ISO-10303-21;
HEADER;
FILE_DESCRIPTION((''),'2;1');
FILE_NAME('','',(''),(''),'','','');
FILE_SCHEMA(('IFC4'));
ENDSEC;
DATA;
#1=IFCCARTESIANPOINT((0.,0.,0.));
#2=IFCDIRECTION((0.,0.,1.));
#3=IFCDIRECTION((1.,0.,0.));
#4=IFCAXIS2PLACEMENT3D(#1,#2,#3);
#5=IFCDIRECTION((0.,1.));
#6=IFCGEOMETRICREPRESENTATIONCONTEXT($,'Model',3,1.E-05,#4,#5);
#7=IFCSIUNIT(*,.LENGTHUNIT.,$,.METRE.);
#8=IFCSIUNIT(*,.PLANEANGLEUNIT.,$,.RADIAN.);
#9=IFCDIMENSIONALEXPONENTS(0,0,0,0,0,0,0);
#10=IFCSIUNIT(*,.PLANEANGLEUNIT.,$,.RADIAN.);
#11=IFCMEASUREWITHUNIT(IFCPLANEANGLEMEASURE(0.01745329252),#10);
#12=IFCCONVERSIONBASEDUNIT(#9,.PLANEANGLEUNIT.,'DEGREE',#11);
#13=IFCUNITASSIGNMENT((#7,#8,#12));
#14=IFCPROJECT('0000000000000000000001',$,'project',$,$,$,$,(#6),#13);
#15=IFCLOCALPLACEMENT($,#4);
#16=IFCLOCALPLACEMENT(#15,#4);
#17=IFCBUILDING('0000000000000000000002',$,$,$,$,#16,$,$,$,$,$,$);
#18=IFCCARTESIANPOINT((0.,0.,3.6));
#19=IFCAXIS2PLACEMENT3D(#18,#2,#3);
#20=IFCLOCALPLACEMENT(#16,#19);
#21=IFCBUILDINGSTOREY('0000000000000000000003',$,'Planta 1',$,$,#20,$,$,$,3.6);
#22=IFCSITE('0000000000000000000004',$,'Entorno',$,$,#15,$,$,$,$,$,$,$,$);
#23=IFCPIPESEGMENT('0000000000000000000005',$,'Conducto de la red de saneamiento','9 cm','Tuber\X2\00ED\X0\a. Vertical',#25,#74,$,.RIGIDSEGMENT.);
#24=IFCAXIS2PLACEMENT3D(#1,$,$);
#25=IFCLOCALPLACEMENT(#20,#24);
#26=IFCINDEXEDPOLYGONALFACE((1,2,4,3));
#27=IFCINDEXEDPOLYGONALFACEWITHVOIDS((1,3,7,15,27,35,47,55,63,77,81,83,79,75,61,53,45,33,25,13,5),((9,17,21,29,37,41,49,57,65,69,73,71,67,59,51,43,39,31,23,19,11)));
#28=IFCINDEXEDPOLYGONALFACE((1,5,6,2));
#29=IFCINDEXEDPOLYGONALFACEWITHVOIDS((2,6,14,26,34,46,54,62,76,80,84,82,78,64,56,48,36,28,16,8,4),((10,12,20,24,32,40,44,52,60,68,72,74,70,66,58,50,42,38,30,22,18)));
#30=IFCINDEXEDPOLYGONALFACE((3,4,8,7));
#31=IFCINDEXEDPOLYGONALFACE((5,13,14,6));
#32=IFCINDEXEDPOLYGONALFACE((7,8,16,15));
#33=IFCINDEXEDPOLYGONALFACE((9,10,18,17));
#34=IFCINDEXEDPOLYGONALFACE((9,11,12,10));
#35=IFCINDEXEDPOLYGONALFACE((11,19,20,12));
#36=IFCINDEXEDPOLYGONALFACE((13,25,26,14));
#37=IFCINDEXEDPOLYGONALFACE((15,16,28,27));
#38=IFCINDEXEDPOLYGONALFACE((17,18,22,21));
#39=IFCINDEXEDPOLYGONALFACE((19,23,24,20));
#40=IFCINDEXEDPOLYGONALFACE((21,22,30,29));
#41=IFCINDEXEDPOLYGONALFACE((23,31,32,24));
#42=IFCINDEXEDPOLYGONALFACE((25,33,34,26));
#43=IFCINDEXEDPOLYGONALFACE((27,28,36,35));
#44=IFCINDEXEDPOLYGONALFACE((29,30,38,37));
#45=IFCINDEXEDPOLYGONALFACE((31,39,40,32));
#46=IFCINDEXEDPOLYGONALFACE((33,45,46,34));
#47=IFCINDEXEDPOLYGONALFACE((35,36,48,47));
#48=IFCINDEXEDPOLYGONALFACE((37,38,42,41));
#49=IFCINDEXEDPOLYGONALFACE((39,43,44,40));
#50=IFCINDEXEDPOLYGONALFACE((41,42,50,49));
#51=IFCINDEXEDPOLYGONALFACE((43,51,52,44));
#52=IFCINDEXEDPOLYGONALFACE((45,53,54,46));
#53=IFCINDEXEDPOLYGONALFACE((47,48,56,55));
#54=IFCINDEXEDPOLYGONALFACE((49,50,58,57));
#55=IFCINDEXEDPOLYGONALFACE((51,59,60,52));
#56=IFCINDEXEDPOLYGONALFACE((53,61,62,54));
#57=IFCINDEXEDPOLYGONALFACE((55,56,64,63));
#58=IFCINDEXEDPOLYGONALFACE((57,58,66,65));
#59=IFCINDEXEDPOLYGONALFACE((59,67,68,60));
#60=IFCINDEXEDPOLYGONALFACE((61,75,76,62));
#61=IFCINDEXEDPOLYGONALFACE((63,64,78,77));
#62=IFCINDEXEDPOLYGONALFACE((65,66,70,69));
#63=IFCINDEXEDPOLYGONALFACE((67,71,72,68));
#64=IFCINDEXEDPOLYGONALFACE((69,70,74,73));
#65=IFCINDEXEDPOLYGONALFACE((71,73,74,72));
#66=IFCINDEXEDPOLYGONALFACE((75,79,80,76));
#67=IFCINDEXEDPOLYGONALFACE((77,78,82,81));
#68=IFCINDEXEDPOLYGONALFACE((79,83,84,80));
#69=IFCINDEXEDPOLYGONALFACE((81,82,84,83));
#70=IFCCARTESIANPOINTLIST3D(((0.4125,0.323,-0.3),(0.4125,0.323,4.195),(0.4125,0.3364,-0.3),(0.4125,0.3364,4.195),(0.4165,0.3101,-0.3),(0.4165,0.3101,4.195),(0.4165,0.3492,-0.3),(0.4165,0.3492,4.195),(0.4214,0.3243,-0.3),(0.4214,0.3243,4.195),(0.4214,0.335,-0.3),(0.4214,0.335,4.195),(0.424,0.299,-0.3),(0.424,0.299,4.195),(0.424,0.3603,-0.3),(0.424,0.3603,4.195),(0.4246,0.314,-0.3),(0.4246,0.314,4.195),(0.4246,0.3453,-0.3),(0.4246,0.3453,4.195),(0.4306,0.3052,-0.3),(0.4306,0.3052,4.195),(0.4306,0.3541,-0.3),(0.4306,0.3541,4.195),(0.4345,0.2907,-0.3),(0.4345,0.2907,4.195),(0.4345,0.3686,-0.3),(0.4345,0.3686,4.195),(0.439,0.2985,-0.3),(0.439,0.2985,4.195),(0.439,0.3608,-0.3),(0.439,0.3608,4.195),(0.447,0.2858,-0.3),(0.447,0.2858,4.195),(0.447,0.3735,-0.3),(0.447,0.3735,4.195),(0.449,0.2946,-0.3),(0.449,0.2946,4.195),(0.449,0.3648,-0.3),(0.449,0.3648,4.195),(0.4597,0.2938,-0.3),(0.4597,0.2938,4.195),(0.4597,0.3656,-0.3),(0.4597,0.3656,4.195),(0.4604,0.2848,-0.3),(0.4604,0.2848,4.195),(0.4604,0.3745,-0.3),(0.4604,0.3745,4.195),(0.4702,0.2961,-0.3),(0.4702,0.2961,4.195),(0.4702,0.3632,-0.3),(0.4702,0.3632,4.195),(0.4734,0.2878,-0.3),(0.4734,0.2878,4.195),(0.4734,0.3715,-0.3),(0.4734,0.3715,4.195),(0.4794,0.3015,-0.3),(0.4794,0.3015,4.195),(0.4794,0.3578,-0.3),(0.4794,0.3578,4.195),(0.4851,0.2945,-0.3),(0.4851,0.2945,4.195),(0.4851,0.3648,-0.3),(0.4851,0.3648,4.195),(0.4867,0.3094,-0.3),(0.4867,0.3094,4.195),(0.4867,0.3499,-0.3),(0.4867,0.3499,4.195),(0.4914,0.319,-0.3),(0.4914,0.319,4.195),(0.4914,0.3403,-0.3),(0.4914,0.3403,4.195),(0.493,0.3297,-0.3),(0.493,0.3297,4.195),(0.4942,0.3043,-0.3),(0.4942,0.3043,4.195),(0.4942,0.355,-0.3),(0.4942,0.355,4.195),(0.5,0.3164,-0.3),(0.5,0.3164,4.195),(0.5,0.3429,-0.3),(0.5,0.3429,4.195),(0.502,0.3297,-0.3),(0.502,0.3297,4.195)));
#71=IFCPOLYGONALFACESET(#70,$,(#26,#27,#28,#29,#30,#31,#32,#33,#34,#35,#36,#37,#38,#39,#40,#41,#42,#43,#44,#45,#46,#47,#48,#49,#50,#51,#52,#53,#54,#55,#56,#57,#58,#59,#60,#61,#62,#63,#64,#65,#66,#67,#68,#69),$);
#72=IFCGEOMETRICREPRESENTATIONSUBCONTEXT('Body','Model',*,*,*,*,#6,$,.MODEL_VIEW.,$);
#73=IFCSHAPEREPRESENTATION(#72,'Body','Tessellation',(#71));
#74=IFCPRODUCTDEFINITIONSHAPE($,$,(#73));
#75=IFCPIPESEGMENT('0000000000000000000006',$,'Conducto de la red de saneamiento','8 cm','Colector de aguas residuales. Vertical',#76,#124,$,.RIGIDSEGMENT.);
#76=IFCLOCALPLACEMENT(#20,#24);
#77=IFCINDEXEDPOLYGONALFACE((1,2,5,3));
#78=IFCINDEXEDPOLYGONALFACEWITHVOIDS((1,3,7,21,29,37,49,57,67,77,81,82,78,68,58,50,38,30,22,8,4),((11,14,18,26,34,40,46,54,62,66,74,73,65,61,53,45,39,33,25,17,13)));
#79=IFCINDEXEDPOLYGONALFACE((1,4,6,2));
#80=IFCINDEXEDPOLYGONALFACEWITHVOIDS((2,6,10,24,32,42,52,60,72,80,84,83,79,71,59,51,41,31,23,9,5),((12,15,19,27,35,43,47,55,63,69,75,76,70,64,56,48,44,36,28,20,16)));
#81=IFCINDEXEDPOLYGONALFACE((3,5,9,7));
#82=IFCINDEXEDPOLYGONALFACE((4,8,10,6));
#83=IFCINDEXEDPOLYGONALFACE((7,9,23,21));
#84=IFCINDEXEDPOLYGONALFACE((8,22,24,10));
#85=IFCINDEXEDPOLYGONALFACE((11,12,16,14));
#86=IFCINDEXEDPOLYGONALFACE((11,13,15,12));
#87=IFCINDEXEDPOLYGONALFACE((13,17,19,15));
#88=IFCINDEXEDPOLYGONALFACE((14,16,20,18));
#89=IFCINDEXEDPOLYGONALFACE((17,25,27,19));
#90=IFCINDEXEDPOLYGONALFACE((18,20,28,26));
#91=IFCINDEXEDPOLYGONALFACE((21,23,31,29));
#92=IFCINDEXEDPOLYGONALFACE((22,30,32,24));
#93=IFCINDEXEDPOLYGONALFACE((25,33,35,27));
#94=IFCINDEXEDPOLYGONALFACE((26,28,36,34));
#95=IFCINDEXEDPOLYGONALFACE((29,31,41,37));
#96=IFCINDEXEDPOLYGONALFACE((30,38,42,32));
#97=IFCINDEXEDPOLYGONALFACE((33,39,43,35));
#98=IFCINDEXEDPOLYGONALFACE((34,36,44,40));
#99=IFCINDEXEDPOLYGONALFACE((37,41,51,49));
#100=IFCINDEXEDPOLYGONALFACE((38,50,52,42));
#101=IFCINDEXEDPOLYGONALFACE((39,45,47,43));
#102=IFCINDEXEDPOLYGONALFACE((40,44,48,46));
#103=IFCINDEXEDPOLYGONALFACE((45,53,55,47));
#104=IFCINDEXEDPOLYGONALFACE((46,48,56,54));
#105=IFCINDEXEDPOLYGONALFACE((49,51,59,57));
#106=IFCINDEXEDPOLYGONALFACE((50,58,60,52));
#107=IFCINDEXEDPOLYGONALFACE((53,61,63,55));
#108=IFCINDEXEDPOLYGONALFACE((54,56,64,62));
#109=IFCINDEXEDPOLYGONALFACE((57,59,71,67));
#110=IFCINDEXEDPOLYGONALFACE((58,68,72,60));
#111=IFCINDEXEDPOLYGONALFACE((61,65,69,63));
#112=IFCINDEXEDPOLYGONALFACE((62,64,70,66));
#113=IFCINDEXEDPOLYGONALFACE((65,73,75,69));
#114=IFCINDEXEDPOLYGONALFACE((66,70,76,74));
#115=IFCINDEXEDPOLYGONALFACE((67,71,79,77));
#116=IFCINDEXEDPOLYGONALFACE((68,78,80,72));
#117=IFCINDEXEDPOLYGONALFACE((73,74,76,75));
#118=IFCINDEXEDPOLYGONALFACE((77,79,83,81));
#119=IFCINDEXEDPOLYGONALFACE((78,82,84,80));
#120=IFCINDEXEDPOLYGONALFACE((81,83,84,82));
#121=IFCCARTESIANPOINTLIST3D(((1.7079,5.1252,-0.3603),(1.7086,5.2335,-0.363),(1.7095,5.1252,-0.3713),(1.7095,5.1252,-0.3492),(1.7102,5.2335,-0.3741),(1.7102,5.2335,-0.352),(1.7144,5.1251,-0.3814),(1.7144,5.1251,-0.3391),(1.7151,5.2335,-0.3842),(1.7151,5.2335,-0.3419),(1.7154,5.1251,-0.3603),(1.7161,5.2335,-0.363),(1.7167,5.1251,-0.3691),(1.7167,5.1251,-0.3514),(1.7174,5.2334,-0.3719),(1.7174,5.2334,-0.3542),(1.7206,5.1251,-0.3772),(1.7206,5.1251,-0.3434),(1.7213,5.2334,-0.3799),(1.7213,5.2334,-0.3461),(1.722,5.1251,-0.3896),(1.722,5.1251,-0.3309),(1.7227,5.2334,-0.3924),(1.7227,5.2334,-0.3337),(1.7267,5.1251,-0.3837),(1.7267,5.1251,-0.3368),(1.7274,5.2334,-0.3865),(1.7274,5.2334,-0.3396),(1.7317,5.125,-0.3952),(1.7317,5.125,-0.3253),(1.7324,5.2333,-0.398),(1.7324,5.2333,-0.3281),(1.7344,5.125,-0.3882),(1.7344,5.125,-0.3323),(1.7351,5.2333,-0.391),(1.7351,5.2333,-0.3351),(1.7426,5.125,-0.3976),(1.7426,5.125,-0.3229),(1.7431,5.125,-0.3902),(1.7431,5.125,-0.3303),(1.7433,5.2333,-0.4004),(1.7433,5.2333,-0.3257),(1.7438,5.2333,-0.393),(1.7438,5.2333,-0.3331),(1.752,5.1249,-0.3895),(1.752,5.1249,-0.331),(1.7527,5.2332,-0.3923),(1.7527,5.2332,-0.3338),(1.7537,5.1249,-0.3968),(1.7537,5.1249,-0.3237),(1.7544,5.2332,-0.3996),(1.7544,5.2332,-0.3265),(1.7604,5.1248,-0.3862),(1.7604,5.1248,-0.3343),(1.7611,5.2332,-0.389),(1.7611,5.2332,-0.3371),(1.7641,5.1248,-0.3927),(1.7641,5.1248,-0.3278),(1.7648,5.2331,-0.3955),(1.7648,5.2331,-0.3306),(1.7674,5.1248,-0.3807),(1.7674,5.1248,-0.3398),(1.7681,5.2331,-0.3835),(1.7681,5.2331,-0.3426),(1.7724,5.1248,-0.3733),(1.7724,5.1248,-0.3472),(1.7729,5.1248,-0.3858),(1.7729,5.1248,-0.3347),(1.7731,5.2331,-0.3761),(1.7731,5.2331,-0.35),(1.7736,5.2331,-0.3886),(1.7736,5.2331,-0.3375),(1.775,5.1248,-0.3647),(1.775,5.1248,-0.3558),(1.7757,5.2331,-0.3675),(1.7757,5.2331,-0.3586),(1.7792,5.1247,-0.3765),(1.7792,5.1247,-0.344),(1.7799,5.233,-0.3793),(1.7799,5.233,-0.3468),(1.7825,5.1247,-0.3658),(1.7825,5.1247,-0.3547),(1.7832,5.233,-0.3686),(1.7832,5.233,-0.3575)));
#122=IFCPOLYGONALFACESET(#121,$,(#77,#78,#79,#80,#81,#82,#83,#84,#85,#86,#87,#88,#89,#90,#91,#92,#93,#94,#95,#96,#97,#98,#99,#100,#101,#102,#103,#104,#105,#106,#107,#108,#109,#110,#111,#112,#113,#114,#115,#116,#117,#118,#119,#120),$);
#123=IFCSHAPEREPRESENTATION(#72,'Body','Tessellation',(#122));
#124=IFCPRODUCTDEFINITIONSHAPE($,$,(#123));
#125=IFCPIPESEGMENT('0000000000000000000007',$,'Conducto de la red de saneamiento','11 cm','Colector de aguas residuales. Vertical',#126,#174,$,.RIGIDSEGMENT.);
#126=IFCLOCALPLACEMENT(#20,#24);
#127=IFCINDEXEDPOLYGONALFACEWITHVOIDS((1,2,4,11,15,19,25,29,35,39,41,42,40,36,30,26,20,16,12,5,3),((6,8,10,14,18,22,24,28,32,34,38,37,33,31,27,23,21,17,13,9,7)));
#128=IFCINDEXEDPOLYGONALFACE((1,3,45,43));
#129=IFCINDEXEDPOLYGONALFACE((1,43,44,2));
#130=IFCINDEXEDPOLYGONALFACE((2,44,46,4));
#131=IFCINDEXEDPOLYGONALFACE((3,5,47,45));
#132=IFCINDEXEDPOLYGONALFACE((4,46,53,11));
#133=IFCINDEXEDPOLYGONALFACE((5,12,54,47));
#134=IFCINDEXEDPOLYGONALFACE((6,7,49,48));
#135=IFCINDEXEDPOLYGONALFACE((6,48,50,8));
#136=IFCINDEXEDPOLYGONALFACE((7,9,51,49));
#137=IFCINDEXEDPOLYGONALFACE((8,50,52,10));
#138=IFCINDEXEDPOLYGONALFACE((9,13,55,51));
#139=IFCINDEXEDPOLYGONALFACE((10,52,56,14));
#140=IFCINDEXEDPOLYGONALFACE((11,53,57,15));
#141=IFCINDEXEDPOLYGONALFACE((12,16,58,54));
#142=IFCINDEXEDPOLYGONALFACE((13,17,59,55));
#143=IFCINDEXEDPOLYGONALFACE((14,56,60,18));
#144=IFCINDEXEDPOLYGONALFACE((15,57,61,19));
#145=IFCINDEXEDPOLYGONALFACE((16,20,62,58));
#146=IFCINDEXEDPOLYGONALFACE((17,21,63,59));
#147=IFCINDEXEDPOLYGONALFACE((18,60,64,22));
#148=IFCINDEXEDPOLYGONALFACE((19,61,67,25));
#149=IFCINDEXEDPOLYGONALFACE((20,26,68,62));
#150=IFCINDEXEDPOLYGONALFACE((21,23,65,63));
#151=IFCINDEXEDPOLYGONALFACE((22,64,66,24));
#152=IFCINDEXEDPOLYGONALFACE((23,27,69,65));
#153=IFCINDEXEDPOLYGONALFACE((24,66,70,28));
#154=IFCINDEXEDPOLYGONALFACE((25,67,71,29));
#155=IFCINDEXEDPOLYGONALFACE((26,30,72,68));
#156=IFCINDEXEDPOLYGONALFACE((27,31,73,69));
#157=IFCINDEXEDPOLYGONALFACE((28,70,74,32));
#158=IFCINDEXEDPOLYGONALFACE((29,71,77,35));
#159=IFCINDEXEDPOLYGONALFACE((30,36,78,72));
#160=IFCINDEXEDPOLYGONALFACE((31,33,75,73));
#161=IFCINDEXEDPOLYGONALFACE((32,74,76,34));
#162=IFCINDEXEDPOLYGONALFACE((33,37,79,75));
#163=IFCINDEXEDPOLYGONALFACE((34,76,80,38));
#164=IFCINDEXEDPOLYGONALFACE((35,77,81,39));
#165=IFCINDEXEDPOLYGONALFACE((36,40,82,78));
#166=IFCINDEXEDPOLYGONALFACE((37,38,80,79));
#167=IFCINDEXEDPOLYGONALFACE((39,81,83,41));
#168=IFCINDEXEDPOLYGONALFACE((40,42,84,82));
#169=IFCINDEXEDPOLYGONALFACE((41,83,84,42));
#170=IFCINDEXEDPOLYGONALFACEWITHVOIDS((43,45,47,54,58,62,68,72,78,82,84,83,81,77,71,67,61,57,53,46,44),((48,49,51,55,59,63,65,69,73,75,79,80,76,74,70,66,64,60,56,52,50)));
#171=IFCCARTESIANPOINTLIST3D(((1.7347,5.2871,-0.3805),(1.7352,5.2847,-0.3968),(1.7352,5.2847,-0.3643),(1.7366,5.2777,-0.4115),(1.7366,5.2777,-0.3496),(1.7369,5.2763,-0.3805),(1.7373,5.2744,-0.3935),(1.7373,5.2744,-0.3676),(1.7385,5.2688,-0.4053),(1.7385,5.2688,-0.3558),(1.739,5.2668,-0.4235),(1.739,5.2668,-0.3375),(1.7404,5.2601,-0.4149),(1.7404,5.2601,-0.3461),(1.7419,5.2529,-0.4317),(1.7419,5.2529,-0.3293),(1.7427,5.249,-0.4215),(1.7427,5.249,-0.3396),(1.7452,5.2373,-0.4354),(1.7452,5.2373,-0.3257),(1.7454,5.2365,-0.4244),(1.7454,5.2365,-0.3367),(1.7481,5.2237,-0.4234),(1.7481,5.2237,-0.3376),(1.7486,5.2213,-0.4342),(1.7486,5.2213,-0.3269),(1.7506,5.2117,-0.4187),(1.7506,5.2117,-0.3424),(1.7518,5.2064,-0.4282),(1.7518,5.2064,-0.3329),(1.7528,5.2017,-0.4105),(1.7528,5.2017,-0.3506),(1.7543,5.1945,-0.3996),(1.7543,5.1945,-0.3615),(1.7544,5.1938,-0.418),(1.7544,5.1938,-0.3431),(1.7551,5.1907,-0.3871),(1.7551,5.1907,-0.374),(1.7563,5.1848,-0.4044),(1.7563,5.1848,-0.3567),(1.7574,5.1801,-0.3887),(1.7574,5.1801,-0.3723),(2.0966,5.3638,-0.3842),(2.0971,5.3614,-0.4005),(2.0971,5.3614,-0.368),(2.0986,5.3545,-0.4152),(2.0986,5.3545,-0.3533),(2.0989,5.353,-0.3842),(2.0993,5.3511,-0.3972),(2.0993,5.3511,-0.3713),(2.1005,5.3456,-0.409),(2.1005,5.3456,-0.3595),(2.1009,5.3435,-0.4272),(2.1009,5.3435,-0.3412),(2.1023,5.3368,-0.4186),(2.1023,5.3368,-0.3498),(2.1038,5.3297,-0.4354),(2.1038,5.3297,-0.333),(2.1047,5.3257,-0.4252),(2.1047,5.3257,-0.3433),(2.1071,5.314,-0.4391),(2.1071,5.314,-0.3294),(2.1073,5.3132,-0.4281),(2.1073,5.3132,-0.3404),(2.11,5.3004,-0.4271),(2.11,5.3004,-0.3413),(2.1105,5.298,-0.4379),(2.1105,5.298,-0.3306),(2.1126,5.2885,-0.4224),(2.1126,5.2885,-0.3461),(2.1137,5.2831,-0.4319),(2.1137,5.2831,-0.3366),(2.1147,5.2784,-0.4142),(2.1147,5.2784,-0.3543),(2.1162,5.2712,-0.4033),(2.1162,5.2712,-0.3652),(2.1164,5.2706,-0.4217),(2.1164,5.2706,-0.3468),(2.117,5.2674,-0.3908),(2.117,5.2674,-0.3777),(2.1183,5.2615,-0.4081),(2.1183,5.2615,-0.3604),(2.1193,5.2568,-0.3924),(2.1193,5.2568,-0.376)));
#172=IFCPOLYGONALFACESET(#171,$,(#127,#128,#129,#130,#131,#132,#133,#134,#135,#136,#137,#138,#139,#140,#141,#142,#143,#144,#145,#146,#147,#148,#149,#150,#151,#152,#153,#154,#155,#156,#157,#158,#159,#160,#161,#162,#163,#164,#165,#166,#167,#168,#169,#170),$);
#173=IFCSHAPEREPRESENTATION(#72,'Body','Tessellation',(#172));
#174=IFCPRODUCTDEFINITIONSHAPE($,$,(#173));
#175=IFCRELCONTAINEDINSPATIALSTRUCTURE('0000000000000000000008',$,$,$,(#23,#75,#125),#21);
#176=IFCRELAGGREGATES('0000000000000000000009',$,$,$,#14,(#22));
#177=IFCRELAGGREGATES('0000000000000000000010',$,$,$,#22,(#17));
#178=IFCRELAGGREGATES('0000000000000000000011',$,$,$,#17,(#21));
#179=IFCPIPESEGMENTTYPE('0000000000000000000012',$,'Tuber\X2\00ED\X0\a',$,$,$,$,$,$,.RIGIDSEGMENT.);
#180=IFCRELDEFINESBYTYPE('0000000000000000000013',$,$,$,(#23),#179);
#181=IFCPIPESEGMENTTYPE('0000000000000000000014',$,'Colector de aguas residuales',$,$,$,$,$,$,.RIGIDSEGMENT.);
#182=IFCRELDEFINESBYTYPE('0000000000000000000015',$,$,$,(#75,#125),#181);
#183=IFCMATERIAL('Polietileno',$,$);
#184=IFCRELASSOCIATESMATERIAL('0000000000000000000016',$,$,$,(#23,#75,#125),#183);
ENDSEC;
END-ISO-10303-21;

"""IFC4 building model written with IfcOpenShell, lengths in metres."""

from ifc_helpers import new_model, entity, si_unit, converted_unit, direction, frame, origin_with_axes, origin_2d_with_axis, place, context, subcontext, project, spatial, hollow_circle, extrude, material, type_object, element, save


model = new_model("IFC4")

# Units and contexts
model_context = context("Model", 3, precision=1e-05, world=origin_with_axes(), true_north=direction((0.0, 1.0)))
body_context = subcontext(model_context, "Body", "Model", "MODEL_VIEW")
ifc_project = project(units=[si_unit("LENGTHUNIT", "METRE"), si_unit("PLANEANGLEUNIT", "RADIAN"), converted_unit("PLANEANGLEUNIT", "DEGREE", entity("IfcPlaneAngleMeasure", 0.01745329252), si_unit("PLANEANGLEUNIT", "RADIAN"), dimensions=[0, 0, 0, 0, 0, 0, 0])], contexts=[model_context])

# Site, building, storey
site_placement = place(None, origin_with_axes())
site = spatial("IfcSite", under=ifc_project, at=site_placement, Name="Entorno")
building_placement = place(site_placement, origin_with_axes())
building = spatial("IfcBuilding", under=site, at=building_placement)
storey_placement = place(building_placement, frame((0.0, 0.0, 3.6), z_axis=(0.0, 0.0, 1.0), x_axis=(1.0, 0.0, 0.0)))
storey = spatial("IfcBuildingStorey", under=building, at=storey_placement, Name="Planta 1", Elevation=3.6)

# Shared definitions
ifc_material_1 = material(Name="Polietileno")

# Pipe segments
pipe_segment_type_1 = type_object("IfcPipeSegmentType", Name="Tubería", PredefinedType="RIGIDSEGMENT")
pipe_segment_1_placement = place(storey_placement, frame((0.457, 0.3297, -0.3), z_axis=(0.0, 0.0, 1.0), x_axis=(1.0, 0.0, 0.0)))
element("IfcPipeSegment", 1, at=pipe_segment_1_placement, inside=storey, type_object=pipe_segment_type_1, material=ifc_material_1, Name="Conducto de la red de saneamiento", Description="9 cm", ObjectType="Tubería. Vertical", PredefinedType="RIGIDSEGMENT", context=body_context, shape_type="SweptSolid", body=[
    extrude(hollow_circle(Radius=0.045, WallThickness=0.009, at=origin_2d_with_axis()), origin_with_axes(), (0.0, 0.0, 1.0), 4.495),
])
pipe_segment_type_2 = type_object("IfcPipeSegmentType", Name="Colector de aguas residuales", PredefinedType="RIGIDSEGMENT")
pipe_segment_2_placement = place(storey_placement, frame((1.7454, 5.1249, -0.3603), z_axis=(0.006451, 0.999979, 0.0), x_axis=(-0.999979, 0.006451, 0.0)))
element("IfcPipeSegment", 2, at=pipe_segment_2_placement, inside=storey, type_object=pipe_segment_type_2, material=ifc_material_1, Name="Conducto de la red de saneamiento", Description="8 cm", ObjectType="Colector de aguas residuales. Vertical", PredefinedType="RIGIDSEGMENT", context=body_context, shape_type="SweptSolid", body=[
    extrude(hollow_circle(Radius=0.0375, WallThickness=0.0075, at=origin_2d_with_axis()), origin_with_axes(), (0.0, -0.025791, 0.999667), 0.1084),
])
pipe_segment_3_placement = place(storey_placement, frame((1.7461, 5.2333, -0.3805), z_axis=(0.97825, 0.207428, 0.0), x_axis=(-0.207428, 0.97825, 0.0)))
element("IfcPipeSegment", 3, at=pipe_segment_3_placement, inside=storey, type_object=pipe_segment_type_2, material=ifc_material_1, Name="Conducto de la red de saneamiento", Description="11 cm", ObjectType="Colector de aguas residuales. Vertical", PredefinedType="RIGIDSEGMENT", context=body_context, shape_type="SweptSolid", body=[
    extrude(hollow_circle(Radius=0.055, WallThickness=0.011, at=origin_2d_with_axis()), origin_with_axes(), (0.0, -0.01, 0.99995), 0.37),
])

save(model, "model.ifc")
